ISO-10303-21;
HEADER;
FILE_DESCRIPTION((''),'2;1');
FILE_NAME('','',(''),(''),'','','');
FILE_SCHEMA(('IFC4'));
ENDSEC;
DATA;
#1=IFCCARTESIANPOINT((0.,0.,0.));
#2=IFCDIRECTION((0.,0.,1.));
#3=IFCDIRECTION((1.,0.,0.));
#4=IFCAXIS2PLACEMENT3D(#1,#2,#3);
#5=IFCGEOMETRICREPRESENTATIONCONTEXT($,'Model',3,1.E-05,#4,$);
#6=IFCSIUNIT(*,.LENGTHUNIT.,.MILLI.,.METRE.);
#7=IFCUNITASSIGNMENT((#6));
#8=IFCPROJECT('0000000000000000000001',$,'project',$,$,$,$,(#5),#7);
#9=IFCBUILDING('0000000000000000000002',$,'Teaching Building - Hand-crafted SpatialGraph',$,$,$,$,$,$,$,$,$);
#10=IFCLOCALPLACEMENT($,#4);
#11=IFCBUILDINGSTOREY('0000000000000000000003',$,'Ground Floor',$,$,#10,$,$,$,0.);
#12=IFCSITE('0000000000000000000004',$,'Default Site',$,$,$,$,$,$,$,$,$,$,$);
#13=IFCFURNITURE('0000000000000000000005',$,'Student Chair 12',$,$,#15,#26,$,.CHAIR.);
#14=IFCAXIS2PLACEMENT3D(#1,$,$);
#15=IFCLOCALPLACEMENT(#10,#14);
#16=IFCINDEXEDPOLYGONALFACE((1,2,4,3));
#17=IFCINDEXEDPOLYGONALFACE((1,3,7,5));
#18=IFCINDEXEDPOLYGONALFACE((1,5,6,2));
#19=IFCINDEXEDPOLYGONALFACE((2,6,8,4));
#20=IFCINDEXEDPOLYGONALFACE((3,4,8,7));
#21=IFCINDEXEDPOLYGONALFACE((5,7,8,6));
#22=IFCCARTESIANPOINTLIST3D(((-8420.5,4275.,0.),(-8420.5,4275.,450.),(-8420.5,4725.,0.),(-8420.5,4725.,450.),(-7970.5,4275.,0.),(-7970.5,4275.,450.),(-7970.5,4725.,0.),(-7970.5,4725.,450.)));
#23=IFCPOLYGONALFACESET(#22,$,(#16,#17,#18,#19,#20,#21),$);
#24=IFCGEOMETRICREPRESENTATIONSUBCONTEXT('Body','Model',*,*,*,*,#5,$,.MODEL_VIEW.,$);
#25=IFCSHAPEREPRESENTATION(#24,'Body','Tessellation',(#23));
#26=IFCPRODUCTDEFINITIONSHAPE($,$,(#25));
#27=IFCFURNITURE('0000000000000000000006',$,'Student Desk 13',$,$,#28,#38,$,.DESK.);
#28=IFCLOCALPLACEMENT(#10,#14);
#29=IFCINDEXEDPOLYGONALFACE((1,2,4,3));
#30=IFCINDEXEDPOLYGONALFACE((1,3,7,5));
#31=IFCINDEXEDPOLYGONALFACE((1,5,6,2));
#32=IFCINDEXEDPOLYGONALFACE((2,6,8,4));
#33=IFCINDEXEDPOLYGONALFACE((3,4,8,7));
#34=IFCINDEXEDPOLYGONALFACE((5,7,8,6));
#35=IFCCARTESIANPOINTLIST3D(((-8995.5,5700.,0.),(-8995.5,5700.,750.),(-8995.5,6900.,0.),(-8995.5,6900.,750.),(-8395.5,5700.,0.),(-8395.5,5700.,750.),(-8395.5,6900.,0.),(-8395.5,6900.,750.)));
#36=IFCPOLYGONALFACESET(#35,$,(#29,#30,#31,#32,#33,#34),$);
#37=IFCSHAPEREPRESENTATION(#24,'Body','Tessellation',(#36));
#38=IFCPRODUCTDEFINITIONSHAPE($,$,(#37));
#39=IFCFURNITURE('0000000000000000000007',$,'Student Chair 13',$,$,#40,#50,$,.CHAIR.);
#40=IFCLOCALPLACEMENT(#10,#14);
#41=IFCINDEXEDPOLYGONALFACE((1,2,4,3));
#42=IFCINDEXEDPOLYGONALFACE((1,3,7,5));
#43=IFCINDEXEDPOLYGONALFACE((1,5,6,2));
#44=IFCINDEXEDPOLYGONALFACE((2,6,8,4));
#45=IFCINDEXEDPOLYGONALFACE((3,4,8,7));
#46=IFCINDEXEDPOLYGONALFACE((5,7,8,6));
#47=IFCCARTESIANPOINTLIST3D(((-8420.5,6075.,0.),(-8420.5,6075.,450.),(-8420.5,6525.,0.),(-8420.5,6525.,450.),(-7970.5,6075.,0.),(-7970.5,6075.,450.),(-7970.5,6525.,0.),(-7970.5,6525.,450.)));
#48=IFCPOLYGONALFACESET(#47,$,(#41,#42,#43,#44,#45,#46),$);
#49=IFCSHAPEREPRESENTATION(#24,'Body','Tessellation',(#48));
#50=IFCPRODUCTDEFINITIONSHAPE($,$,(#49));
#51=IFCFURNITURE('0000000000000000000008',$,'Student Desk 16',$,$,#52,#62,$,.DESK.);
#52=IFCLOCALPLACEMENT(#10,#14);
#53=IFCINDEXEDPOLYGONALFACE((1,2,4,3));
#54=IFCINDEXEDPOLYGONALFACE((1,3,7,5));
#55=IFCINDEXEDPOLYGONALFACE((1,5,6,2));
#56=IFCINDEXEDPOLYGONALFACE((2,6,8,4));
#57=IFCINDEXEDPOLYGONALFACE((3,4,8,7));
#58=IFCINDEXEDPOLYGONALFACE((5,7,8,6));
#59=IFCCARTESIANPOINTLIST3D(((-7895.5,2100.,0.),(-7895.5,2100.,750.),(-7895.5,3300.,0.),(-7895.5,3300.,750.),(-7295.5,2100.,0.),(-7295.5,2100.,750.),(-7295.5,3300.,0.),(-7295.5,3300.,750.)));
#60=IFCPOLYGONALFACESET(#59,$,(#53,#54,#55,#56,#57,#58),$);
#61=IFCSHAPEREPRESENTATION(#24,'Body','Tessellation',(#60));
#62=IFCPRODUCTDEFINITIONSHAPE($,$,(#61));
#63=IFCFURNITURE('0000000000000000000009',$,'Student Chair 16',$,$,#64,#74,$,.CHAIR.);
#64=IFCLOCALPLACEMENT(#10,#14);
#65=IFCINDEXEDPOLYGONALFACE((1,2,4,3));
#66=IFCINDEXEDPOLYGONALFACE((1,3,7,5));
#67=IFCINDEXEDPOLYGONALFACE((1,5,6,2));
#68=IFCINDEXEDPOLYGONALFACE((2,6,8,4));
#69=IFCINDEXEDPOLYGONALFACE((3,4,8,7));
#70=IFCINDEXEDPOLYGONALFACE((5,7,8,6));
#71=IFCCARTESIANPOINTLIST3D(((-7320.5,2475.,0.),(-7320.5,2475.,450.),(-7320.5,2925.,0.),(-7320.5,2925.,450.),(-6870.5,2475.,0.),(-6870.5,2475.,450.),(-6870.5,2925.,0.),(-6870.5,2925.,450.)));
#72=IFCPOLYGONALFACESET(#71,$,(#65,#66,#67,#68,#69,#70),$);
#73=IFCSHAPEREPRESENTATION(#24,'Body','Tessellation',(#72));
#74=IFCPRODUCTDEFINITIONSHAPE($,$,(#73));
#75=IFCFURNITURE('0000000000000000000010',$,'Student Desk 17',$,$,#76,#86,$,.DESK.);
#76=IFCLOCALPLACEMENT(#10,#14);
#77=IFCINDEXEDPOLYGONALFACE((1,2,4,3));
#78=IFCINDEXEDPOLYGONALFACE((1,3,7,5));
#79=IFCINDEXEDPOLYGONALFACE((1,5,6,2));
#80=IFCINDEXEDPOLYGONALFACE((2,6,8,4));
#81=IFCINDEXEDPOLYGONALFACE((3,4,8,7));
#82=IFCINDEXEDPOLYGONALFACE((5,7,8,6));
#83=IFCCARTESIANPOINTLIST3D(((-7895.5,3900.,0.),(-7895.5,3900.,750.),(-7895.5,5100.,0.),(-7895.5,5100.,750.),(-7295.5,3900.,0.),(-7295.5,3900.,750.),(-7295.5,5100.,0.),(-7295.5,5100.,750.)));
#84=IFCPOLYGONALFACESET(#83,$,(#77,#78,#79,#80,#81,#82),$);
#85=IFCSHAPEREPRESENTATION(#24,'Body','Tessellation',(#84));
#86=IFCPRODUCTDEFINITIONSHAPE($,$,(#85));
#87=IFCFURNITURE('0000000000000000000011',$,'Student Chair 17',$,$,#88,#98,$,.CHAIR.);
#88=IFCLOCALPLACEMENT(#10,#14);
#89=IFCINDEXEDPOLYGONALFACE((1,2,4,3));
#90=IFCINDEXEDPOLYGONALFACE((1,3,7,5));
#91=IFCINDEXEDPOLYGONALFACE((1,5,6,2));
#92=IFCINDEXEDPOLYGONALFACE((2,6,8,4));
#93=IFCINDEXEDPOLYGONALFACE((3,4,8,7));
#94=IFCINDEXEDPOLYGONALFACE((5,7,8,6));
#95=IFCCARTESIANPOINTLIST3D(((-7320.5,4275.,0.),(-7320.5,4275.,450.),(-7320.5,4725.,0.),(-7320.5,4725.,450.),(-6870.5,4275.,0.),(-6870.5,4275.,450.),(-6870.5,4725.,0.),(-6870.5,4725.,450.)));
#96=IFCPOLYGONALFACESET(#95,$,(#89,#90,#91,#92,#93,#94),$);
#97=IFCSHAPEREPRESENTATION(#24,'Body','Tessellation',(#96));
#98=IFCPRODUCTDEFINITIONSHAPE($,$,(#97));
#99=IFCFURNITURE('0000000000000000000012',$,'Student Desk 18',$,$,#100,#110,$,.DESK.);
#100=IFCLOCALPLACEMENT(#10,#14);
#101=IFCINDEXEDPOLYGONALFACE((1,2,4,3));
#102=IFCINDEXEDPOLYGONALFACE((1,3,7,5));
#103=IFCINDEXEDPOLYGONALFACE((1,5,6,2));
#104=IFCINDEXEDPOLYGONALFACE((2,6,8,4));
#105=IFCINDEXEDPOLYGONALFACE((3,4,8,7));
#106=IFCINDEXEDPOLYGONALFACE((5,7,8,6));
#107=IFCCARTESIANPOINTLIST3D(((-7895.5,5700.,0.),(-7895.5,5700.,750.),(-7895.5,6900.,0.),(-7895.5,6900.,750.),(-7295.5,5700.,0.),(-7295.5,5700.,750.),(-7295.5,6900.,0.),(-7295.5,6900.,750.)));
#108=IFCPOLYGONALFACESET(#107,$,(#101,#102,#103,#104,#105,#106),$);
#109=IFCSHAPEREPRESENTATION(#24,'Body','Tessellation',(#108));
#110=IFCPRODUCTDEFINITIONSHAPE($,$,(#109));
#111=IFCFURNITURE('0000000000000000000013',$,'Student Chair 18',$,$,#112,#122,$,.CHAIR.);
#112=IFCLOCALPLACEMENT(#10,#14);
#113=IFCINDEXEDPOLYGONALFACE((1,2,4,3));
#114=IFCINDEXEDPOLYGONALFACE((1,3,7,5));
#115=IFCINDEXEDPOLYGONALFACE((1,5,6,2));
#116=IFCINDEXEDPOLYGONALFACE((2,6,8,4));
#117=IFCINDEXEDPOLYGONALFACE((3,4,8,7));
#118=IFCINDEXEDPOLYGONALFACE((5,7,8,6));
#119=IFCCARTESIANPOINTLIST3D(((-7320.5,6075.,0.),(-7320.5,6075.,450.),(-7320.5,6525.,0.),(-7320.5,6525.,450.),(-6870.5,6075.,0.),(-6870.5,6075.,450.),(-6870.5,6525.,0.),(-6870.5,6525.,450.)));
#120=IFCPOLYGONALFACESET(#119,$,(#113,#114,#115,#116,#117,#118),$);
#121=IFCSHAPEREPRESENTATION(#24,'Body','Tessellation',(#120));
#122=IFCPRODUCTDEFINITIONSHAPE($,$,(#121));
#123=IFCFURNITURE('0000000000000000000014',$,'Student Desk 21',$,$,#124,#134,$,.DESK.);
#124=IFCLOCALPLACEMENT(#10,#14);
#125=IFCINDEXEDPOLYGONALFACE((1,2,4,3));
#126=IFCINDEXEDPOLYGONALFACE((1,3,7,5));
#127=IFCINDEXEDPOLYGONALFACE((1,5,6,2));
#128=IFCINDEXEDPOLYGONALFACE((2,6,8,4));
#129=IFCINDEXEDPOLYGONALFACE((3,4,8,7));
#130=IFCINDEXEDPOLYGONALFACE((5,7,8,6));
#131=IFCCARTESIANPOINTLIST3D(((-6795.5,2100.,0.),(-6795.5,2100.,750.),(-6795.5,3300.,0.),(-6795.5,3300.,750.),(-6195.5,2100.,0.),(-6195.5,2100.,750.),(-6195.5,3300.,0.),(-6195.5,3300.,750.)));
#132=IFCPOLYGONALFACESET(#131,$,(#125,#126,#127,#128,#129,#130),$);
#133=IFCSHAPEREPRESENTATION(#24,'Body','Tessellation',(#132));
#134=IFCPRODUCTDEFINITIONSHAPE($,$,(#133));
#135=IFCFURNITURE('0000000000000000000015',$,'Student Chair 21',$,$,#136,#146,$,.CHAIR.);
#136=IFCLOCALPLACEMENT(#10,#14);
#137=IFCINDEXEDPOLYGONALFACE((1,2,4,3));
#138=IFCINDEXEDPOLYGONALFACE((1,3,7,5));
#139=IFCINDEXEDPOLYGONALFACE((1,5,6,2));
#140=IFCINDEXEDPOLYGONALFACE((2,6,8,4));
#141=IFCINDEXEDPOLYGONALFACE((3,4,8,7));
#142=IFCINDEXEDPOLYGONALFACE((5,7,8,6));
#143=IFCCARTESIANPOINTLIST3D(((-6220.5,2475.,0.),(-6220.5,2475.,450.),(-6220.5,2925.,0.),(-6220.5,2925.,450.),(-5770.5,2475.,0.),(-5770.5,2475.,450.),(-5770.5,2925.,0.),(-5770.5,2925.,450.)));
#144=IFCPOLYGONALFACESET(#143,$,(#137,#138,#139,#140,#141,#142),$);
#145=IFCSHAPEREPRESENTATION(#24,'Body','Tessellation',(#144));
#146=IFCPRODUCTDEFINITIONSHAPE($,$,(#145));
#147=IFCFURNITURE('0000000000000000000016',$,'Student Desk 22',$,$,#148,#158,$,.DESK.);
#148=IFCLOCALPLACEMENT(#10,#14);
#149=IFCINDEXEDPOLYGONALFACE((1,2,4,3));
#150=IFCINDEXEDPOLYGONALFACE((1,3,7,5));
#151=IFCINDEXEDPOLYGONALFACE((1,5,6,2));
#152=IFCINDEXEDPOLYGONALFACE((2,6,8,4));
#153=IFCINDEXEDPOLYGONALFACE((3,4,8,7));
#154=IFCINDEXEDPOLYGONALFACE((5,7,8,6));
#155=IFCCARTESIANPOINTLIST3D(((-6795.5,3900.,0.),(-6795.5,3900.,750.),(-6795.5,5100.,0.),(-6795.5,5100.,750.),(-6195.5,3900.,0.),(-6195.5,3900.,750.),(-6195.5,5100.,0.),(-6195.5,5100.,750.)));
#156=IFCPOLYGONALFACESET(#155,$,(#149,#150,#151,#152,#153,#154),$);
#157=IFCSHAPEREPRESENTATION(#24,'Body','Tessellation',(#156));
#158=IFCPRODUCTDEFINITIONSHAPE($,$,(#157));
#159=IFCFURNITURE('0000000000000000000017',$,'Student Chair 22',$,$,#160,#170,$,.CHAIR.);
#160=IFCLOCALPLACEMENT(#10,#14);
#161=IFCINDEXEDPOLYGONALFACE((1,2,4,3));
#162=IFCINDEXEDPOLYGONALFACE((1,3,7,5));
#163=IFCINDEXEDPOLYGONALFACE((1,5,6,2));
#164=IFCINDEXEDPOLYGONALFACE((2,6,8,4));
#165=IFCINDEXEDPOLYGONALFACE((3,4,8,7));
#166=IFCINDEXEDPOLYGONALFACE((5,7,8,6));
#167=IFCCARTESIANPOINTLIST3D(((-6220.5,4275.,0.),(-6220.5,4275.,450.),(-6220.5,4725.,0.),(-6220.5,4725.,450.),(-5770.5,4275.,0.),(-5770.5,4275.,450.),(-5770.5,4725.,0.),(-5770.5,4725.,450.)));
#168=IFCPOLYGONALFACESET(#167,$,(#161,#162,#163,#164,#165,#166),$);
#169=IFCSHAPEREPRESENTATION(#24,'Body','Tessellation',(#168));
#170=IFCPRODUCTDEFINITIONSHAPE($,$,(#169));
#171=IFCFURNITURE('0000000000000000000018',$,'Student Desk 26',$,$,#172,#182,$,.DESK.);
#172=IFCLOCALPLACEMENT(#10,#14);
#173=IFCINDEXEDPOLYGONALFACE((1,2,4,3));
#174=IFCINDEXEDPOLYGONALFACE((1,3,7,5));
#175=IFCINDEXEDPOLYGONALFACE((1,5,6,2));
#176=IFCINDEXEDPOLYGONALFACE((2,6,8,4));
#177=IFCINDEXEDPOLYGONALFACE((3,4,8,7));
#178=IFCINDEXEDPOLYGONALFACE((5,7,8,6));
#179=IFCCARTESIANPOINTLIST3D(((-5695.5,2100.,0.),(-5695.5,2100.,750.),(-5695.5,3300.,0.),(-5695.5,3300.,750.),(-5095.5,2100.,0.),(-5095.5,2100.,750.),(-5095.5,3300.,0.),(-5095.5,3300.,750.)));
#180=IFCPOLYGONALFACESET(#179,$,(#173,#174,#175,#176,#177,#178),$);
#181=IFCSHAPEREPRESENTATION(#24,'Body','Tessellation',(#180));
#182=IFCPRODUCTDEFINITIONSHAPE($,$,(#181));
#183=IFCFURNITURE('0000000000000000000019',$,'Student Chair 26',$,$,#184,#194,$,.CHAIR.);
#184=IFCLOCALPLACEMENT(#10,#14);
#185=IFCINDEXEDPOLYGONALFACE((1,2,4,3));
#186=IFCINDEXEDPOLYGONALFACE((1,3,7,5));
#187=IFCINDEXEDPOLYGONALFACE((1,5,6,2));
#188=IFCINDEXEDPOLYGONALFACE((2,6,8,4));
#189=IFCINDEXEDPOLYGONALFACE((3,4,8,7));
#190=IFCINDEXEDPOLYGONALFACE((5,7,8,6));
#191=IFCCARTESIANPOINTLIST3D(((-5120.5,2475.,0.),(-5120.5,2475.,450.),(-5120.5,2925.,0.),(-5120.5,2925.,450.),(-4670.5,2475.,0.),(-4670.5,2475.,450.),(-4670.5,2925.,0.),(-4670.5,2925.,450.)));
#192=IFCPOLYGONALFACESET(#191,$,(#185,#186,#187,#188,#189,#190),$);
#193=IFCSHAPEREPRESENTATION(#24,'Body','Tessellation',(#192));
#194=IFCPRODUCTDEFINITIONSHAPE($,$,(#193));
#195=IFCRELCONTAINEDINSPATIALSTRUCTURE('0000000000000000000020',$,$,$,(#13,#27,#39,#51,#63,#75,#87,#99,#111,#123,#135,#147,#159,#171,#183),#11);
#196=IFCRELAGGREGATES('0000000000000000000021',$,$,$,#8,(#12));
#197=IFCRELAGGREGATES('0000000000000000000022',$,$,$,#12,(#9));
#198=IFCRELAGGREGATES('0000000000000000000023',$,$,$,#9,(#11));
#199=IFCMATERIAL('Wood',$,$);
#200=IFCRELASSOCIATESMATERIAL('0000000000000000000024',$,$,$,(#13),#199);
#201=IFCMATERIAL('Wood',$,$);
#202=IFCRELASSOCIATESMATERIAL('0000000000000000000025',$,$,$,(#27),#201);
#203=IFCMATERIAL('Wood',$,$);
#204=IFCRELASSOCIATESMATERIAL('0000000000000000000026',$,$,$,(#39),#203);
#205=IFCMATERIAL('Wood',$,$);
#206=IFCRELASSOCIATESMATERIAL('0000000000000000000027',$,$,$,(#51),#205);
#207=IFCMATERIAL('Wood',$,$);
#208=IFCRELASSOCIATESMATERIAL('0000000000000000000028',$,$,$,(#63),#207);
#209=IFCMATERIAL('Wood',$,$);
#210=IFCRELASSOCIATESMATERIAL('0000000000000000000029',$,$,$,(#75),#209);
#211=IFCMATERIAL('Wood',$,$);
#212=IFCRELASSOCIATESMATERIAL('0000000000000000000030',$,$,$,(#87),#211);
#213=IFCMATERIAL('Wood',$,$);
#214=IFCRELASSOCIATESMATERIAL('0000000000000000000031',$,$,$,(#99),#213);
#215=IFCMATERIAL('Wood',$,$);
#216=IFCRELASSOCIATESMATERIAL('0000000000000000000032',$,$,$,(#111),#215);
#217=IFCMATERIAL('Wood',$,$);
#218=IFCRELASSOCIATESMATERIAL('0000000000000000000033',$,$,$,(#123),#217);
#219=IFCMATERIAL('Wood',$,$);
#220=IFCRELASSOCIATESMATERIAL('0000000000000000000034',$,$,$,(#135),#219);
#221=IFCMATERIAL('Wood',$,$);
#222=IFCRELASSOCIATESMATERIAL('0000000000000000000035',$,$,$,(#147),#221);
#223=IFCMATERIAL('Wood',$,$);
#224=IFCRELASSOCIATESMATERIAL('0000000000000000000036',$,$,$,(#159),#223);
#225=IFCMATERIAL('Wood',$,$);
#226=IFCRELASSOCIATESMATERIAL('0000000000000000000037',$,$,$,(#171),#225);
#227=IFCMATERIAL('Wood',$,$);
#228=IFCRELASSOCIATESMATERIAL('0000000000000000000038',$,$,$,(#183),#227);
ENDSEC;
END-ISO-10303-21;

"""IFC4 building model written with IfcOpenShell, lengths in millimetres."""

from ifc_helpers import new_model, si_unit, frame, origin_with_axes, origin_2d, place, context, subcontext, project, spatial, rectangle, extrude, material, element, save


model = new_model("IFC4")

# Units and contexts
model_context = context("Model", 3, precision=1e-05, world=origin_with_axes())
body_context = subcontext(model_context, "Body", "Model", "MODEL_VIEW")
ifc_project = project(units=[si_unit("LENGTHUNIT", "METRE", prefix="MILLI")], contexts=[model_context])

# Site, building, storey
site = spatial("IfcSite", under=ifc_project, Name="Default Site")
building = spatial("IfcBuilding", under=site, Name="Teaching Building - Hand-crafted SpatialGraph")
storey_placement = place(None, origin_with_axes())
storey = spatial("IfcBuildingStorey", under=building, at=storey_placement, Name="Ground Floor", Elevation=0.0)

# Furniture
ifc_material_1 = material(Name="Wood")
furniture_1_placement = place(storey_placement, frame((-8195.5, 4500.0, 0.0), z_axis=(0.0, 0.0, 1.0), x_axis=(1.0, 0.0, 0.0)))
element("IfcFurniture", 1, at=furniture_1_placement, inside=storey, material=ifc_material_1, Name="Student Chair 12", PredefinedType="CHAIR", context=body_context, shape_type="SweptSolid", body=[
    extrude(rectangle(XDim=450.0, YDim=450.0, at=origin_2d()), origin_with_axes(), (0.0, 0.0, 1.0), 450.0),
])
ifc_material_2 = material(Name="Wood")
furniture_2_placement = place(storey_placement, frame((-8695.5, 6300.0, 0.0), z_axis=(0.0, 0.0, 1.0), x_axis=(0.0, 1.0, 0.0)))
element("IfcFurniture", 2, at=furniture_2_placement, inside=storey, material=ifc_material_2, Name="Student Desk 13", PredefinedType="DESK", context=body_context, shape_type="SweptSolid", body=[
    extrude(rectangle(XDim=1200.0, YDim=600.0, at=origin_2d()), origin_with_axes(), (0.0, 0.0, 1.0), 750.0),
])
ifc_material_3 = material(Name="Wood")
furniture_3_placement = place(storey_placement, frame((-8195.5, 6300.0, 0.0), z_axis=(0.0, 0.0, 1.0), x_axis=(1.0, 0.0, 0.0)))
element("IfcFurniture", 3, at=furniture_3_placement, inside=storey, material=ifc_material_3, Name="Student Chair 13", PredefinedType="CHAIR", context=body_context, shape_type="SweptSolid", body=[
    extrude(rectangle(XDim=450.0, YDim=450.0, at=origin_2d()), origin_with_axes(), (0.0, 0.0, 1.0), 450.0),
])
ifc_material_4 = material(Name="Wood")
furniture_4_placement = place(storey_placement, frame((-7595.5, 2700.0, 0.0), z_axis=(0.0, 0.0, 1.0), x_axis=(0.0, 1.0, 0.0)))
element("IfcFurniture", 4, at=furniture_4_placement, inside=storey, material=ifc_material_4, Name="Student Desk 16", PredefinedType="DESK", context=body_context, shape_type="SweptSolid", body=[
    extrude(rectangle(XDim=1200.0, YDim=600.0, at=origin_2d()), origin_with_axes(), (0.0, 0.0, 1.0), 750.0),
])
ifc_material_5 = material(Name="Wood")
furniture_5_placement = place(storey_placement, frame((-7095.5, 2700.0, 0.0), z_axis=(0.0, 0.0, 1.0), x_axis=(1.0, 0.0, 0.0)))
element("IfcFurniture", 5, at=furniture_5_placement, inside=storey, material=ifc_material_5, Name="Student Chair 16", PredefinedType="CHAIR", context=body_context, shape_type="SweptSolid", body=[
    extrude(rectangle(XDim=450.0, YDim=450.0, at=origin_2d()), origin_with_axes(), (0.0, 0.0, 1.0), 450.0),
])
ifc_material_6 = material(Name="Wood")
furniture_6_placement = place(storey_placement, frame((-7595.5, 4500.0, 0.0), z_axis=(0.0, 0.0, 1.0), x_axis=(0.0, 1.0, 0.0)))
element("IfcFurniture", 6, at=furniture_6_placement, inside=storey, material=ifc_material_6, Name="Student Desk 17", PredefinedType="DESK", context=body_context, shape_type="SweptSolid", body=[
    extrude(rectangle(XDim=1200.0, YDim=600.0, at=origin_2d()), origin_with_axes(), (0.0, 0.0, 1.0), 750.0),
])
ifc_material_7 = material(Name="Wood")
furniture_7_placement = place(storey_placement, frame((-7095.5, 4500.0, 0.0), z_axis=(0.0, 0.0, 1.0), x_axis=(1.0, 0.0, 0.0)))
element("IfcFurniture", 7, at=furniture_7_placement, inside=storey, material=ifc_material_7, Name="Student Chair 17", PredefinedType="CHAIR", context=body_context, shape_type="SweptSolid", body=[
    extrude(rectangle(XDim=450.0, YDim=450.0, at=origin_2d()), origin_with_axes(), (0.0, 0.0, 1.0), 450.0),
])
ifc_material_8 = material(Name="Wood")
furniture_8_placement = place(storey_placement, frame((-7595.5, 6300.0, 0.0), z_axis=(0.0, 0.0, 1.0), x_axis=(0.0, 1.0, 0.0)))
element("IfcFurniture", 8, at=furniture_8_placement, inside=storey, material=ifc_material_8, Name="Student Desk 18", PredefinedType="DESK", context=body_context, shape_type="SweptSolid", body=[
    extrude(rectangle(XDim=1200.0, YDim=600.0, at=origin_2d()), origin_with_axes(), (0.0, 0.0, 1.0), 750.0),
])
ifc_material_9 = material(Name="Wood")
furniture_9_placement = place(storey_placement, frame((-7095.5, 6300.0, 0.0), z_axis=(0.0, 0.0, 1.0), x_axis=(1.0, 0.0, 0.0)))
element("IfcFurniture", 9, at=furniture_9_placement, inside=storey, material=ifc_material_9, Name="Student Chair 18", PredefinedType="CHAIR", context=body_context, shape_type="SweptSolid", body=[
    extrude(rectangle(XDim=450.0, YDim=450.0, at=origin_2d()), origin_with_axes(), (0.0, 0.0, 1.0), 450.0),
])
ifc_material_10 = material(Name="Wood")
furniture_10_placement = place(storey_placement, frame((-6495.5, 2700.0, 0.0), z_axis=(0.0, 0.0, 1.0), x_axis=(0.0, 1.0, 0.0)))
element("IfcFurniture", 10, at=furniture_10_placement, inside=storey, material=ifc_material_10, Name="Student Desk 21", PredefinedType="DESK", context=body_context, shape_type="SweptSolid", body=[
    extrude(rectangle(XDim=1200.0, YDim=600.0, at=origin_2d()), origin_with_axes(), (0.0, 0.0, 1.0), 750.0),
])
ifc_material_11 = material(Name="Wood")
furniture_11_placement = place(storey_placement, frame((-5995.5, 2700.0, 0.0), z_axis=(0.0, 0.0, 1.0), x_axis=(1.0, 0.0, 0.0)))
element("IfcFurniture", 11, at=furniture_11_placement, inside=storey, material=ifc_material_11, Name="Student Chair 21", PredefinedType="CHAIR", context=body_context, shape_type="SweptSolid", body=[
    extrude(rectangle(XDim=450.0, YDim=450.0, at=origin_2d()), origin_with_axes(), (0.0, 0.0, 1.0), 450.0),
])
ifc_material_12 = material(Name="Wood")
furniture_12_placement = place(storey_placement, frame((-6495.5, 4500.0, 0.0), z_axis=(0.0, 0.0, 1.0), x_axis=(0.0, 1.0, 0.0)))
element("IfcFurniture", 12, at=furniture_12_placement, inside=storey, material=ifc_material_12, Name="Student Desk 22", PredefinedType="DESK", context=body_context, shape_type="SweptSolid", body=[
    extrude(rectangle(XDim=1200.0, YDim=600.0, at=origin_2d()), origin_with_axes(), (0.0, 0.0, 1.0), 750.0),
])
ifc_material_13 = material(Name="Wood")
furniture_13_placement = place(storey_placement, frame((-5995.5, 4500.0, 0.0), z_axis=(0.0, 0.0, 1.0), x_axis=(1.0, 0.0, 0.0)))
element("IfcFurniture", 13, at=furniture_13_placement, inside=storey, material=ifc_material_13, Name="Student Chair 22", PredefinedType="CHAIR", context=body_context, shape_type="SweptSolid", body=[
    extrude(rectangle(XDim=450.0, YDim=450.0, at=origin_2d()), origin_with_axes(), (0.0, 0.0, 1.0), 450.0),
])
ifc_material_14 = material(Name="Wood")
furniture_14_placement = place(storey_placement, frame((-5395.5, 2700.0, 0.0), z_axis=(0.0, 0.0, 1.0), x_axis=(0.0, 1.0, 0.0)))
element("IfcFurniture", 14, at=furniture_14_placement, inside=storey, material=ifc_material_14, Name="Student Desk 26", PredefinedType="DESK", context=body_context, shape_type="SweptSolid", body=[
    extrude(rectangle(XDim=1200.0, YDim=600.0, at=origin_2d()), origin_with_axes(), (0.0, 0.0, 1.0), 750.0),
])
ifc_material_15 = material(Name="Wood")
furniture_15_placement = place(storey_placement, frame((-4895.5, 2700.0, 0.0), z_axis=(0.0, 0.0, 1.0), x_axis=(1.0, 0.0, 0.0)))
element("IfcFurniture", 15, at=furniture_15_placement, inside=storey, material=ifc_material_15, Name="Student Chair 26", PredefinedType="CHAIR", context=body_context, shape_type="SweptSolid", body=[
    extrude(rectangle(XDim=450.0, YDim=450.0, at=origin_2d()), origin_with_axes(), (0.0, 0.0, 1.0), 450.0),
])

save(model, "model.ifc")
